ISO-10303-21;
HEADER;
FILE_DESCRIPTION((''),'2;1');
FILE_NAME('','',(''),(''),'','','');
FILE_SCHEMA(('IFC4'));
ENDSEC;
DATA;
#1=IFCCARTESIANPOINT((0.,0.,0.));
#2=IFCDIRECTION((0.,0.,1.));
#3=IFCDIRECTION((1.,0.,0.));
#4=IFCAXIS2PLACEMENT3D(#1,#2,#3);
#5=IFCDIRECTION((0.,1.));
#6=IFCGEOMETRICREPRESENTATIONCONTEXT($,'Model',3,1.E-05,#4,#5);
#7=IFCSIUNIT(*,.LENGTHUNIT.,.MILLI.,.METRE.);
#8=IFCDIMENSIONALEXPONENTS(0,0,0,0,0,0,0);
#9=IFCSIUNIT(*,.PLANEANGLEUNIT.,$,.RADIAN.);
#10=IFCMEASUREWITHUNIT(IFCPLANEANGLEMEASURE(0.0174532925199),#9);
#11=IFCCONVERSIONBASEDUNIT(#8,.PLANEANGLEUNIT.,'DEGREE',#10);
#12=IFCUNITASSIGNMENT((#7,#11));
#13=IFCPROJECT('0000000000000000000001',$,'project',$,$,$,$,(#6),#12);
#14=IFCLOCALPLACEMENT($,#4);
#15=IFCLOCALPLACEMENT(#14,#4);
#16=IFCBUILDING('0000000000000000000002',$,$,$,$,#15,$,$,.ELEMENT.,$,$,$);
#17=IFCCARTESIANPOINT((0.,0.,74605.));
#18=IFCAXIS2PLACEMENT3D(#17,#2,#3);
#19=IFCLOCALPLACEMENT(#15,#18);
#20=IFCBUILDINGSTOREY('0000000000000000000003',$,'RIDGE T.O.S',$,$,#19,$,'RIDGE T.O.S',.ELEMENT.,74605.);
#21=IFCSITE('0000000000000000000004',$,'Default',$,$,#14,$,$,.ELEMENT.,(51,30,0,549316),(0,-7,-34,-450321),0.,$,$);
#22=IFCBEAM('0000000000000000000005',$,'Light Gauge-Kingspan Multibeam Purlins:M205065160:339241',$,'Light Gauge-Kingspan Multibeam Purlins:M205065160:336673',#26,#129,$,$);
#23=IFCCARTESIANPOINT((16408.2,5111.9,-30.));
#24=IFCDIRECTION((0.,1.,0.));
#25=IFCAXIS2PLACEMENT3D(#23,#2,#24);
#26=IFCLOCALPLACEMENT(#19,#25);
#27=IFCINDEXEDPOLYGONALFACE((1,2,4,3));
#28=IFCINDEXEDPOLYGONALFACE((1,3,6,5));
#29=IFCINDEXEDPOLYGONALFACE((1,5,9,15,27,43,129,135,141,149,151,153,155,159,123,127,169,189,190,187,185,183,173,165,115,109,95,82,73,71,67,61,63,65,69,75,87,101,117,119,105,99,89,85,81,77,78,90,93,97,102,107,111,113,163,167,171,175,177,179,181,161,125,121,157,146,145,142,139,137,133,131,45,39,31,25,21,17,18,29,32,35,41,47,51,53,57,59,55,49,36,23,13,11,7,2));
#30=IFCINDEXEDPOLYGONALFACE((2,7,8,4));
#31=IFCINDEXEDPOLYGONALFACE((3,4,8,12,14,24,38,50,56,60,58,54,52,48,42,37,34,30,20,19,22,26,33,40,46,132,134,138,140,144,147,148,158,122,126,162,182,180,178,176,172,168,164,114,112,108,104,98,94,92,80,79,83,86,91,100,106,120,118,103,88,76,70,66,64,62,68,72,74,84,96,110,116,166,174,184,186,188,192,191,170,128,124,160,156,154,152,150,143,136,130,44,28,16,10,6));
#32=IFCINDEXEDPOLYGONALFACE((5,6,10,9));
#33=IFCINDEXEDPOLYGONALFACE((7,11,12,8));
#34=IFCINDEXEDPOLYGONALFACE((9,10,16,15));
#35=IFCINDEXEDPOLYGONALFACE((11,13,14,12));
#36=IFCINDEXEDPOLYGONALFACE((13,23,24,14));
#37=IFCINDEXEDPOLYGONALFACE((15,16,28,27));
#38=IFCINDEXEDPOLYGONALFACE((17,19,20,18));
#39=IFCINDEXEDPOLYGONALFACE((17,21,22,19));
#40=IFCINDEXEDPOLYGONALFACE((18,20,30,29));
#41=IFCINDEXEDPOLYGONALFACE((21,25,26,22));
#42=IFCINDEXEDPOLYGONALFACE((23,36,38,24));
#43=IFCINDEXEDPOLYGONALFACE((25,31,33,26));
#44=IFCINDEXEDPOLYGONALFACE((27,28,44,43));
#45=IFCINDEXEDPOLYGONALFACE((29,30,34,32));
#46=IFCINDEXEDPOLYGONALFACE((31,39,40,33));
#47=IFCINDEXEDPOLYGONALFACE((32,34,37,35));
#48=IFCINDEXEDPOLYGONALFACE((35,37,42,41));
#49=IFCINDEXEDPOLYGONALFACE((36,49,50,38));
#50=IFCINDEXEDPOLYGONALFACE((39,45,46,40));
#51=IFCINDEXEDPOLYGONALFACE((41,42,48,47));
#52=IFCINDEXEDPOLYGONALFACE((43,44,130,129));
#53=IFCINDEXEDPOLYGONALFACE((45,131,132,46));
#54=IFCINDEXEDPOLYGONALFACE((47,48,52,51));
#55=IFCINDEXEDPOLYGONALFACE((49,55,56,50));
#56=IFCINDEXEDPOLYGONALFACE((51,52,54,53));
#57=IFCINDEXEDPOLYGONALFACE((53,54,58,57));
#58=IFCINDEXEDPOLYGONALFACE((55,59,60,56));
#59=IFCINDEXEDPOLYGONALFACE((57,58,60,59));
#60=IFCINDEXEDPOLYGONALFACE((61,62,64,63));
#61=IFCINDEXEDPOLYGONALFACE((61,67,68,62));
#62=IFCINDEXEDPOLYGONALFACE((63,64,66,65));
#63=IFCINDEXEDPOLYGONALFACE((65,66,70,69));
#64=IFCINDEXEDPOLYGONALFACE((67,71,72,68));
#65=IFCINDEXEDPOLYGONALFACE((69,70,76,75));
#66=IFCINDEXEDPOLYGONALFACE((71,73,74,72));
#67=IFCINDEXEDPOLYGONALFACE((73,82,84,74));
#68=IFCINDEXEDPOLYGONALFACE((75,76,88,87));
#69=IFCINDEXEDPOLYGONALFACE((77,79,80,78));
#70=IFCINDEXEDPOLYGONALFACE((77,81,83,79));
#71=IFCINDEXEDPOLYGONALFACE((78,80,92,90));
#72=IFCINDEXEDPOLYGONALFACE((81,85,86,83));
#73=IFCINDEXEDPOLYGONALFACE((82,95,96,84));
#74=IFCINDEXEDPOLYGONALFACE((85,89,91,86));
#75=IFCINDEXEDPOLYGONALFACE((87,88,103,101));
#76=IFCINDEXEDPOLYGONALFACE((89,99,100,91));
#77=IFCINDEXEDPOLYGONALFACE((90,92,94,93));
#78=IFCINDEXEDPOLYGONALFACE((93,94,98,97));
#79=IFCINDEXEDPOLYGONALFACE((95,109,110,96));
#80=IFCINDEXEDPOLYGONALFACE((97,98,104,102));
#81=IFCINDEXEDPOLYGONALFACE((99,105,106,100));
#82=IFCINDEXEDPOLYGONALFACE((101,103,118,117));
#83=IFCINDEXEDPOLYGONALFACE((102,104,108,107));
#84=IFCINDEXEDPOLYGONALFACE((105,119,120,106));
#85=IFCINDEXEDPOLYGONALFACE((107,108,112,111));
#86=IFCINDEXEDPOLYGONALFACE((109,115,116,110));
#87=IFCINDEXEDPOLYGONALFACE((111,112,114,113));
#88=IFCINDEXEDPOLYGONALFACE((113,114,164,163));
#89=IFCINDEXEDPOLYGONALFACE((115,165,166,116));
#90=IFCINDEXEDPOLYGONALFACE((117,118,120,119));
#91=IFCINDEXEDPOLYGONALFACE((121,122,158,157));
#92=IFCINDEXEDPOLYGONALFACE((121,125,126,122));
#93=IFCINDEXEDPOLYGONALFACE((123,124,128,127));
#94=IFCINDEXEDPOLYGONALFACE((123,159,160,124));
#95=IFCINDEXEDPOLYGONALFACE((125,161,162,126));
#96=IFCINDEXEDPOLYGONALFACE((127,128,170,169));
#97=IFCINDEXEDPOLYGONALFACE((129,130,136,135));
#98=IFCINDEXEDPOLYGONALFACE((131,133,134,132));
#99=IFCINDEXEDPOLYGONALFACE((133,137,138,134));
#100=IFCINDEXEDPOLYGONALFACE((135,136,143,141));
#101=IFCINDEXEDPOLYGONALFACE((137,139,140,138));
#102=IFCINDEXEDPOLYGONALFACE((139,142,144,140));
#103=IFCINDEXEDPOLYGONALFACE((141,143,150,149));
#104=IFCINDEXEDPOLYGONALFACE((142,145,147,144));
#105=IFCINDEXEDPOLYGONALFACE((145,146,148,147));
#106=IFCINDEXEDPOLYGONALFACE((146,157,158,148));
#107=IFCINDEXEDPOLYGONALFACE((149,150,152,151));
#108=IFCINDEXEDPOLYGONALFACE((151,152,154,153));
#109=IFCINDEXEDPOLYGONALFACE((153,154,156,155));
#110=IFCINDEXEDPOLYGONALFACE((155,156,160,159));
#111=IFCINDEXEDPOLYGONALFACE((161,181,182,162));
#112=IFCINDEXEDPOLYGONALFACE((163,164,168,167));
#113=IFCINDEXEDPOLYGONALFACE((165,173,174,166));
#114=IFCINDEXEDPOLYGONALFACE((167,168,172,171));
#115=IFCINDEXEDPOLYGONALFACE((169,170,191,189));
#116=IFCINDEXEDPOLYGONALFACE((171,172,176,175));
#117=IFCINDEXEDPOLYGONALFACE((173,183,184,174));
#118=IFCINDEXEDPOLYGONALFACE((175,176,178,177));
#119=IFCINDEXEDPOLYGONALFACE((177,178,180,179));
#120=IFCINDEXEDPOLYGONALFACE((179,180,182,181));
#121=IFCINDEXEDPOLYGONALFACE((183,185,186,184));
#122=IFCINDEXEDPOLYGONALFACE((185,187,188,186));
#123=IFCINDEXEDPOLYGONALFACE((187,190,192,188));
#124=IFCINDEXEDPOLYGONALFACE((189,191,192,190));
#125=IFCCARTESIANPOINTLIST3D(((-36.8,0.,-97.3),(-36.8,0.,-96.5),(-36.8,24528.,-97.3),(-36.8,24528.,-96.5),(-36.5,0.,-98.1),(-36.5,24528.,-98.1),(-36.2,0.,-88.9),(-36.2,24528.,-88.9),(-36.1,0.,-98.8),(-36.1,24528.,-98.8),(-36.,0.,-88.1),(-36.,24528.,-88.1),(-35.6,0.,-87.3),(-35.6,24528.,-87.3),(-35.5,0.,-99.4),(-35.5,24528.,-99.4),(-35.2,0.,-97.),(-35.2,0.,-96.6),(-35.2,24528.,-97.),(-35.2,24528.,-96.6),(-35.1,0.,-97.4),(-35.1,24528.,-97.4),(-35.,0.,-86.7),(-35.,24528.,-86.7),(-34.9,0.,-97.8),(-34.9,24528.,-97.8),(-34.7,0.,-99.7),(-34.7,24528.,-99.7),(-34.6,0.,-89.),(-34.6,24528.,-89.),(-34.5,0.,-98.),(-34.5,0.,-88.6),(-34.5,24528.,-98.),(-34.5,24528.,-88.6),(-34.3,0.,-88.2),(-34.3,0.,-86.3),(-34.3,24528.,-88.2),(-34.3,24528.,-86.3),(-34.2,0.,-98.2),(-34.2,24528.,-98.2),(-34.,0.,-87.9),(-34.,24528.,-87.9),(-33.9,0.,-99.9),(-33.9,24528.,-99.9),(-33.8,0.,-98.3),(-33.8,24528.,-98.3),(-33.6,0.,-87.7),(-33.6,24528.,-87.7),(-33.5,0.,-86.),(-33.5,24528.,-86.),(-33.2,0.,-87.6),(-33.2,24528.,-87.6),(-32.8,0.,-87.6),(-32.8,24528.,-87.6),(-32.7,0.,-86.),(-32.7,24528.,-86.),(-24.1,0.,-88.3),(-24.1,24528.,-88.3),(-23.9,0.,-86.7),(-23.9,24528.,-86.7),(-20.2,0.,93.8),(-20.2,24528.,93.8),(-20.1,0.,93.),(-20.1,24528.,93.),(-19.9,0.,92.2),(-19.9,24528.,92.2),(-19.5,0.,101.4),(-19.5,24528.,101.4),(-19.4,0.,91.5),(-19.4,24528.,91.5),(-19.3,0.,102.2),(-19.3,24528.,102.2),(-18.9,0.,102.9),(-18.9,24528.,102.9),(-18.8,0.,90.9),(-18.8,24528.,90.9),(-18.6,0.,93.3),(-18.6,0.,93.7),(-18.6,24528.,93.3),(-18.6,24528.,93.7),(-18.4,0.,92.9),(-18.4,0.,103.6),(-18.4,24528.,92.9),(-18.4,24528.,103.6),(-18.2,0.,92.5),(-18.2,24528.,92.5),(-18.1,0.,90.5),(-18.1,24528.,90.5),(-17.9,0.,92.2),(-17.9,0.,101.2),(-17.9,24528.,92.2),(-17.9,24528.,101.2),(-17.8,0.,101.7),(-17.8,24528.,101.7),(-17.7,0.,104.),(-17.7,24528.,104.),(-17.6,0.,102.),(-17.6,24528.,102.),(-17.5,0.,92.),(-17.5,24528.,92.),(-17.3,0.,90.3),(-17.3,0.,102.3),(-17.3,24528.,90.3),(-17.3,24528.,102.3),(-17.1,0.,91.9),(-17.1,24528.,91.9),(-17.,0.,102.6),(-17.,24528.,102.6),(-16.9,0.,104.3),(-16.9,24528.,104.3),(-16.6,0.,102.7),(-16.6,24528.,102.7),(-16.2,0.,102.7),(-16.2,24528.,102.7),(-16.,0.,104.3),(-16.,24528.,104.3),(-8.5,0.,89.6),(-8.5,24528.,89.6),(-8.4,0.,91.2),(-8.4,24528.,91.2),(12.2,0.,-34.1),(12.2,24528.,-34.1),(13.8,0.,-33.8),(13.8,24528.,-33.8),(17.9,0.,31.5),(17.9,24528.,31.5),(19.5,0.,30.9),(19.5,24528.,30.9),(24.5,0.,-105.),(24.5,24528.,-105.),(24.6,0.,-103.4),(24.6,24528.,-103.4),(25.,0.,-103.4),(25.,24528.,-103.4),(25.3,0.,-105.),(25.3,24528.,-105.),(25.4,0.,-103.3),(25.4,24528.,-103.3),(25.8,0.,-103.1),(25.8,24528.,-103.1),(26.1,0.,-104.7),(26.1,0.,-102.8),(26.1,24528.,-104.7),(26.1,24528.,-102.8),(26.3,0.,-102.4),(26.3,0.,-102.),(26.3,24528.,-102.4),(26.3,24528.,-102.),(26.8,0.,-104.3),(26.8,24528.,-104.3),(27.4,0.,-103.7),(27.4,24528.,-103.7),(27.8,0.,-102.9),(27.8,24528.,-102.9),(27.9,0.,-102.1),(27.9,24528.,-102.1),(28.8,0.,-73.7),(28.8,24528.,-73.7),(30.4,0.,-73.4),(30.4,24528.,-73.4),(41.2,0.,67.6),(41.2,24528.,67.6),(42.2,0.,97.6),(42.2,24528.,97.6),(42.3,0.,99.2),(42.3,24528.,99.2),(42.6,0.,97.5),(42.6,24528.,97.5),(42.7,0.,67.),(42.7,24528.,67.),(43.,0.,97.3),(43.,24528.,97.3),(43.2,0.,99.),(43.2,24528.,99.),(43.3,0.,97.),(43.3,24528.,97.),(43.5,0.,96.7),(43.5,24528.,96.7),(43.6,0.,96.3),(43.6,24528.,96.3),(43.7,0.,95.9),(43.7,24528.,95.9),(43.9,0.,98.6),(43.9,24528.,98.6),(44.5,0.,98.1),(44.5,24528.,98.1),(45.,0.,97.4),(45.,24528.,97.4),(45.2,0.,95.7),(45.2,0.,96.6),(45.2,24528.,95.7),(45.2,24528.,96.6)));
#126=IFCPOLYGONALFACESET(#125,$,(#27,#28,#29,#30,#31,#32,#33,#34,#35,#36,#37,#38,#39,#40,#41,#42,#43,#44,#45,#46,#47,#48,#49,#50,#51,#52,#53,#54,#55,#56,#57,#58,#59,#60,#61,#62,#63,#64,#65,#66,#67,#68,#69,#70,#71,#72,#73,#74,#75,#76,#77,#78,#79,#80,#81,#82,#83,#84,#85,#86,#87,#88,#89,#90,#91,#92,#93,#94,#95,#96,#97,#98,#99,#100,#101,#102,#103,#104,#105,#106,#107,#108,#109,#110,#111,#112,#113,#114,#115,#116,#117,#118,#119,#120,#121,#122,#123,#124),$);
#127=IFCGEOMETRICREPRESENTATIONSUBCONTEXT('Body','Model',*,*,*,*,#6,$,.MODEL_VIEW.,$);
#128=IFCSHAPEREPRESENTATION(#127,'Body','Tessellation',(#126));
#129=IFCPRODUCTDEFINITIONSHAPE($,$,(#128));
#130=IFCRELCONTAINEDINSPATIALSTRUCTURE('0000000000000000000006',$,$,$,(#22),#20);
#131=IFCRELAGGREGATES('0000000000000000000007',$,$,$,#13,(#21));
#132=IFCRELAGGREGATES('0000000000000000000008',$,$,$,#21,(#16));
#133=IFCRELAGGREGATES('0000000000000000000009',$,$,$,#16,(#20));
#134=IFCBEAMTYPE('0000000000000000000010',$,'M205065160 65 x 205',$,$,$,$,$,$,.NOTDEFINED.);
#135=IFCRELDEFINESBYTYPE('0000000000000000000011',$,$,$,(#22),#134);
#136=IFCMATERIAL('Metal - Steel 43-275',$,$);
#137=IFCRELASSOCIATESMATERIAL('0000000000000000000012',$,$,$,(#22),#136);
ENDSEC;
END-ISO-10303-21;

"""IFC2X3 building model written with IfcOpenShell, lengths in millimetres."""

from ifc_helpers import new_model, entity, si_unit, converted_unit, point, direction, frame, frame_2d, origin_with_axes, place, context, subcontext, project, spatial, polyline, circle_curve, parameter, trimmed, segment, composite_curve, outline, extrude, material, type_object, element, save


model = new_model("IFC2X3")

# Units and contexts
model_context = context("Model", 3, precision=1e-05, world=origin_with_axes(), true_north=direction((0.0, 1.0)))
body_context = subcontext(model_context, "Body", "Model", "MODEL_VIEW")
ifc_project = project(units=[si_unit("LENGTHUNIT", "METRE", prefix="MILLI"), converted_unit("PLANEANGLEUNIT", "DEGREE", entity("IfcPlaneAngleMeasure", 0.0174532925199), si_unit("PLANEANGLEUNIT", "RADIAN"), dimensions=[0, 0, 0, 0, 0, 0, 0])], contexts=[model_context])

# Site, building, storey
site_placement = place(None, origin_with_axes())
site = spatial("IfcSite", under=ifc_project, at=site_placement, Name="Default", CompositionType="ELEMENT", RefLatitude=(51, 30, 0, 549316), RefLongitude=(0, -7, -34, -450321), RefElevation=0.0)
building_placement = place(site_placement, origin_with_axes())
building = spatial("IfcBuilding", under=site, at=building_placement, CompositionType="ELEMENT")
storey_placement = place(building_placement, frame((0.0, 0.0, 74605.0), z_axis=(0.0, 0.0, 1.0), x_axis=(1.0, 0.0, 0.0)))
storey = spatial("IfcBuildingStorey", under=building, at=storey_placement, Name="RIDGE T.O.S", LongName="RIDGE T.O.S", CompositionType="ELEMENT", Elevation=74605.0)

# Beam
ifc_material = material(Name="Metal - Steel 43-275")
beam_type_1 = type_object("IfcBeamType", Name="M205065160 65 x 205", PredefinedType="NOTDEFINED")
beam_1_placement = place(storey_placement, frame((16408.2, 5111.9, -30.0), z_axis=(0.0, 0.0, 1.0), x_axis=(0.0, 1.0, 0.0)))
element("IfcBeam", 1, at=beam_1_placement, inside=storey, type_object=beam_type_1, material=ifc_material, Name="Light Gauge-Kingspan Multibeam Purlins:M205065160:339241", ObjectType="Light Gauge-Kingspan Multibeam Purlins:M205065160:336673", context=body_context, shape_type="SweptSolid", body=[
    extrude(outline(composite_curve([segment(polyline([(-33.5, -102.5), (25.1, -102.5)]), True, "CONTINUOUS"), segment(trimmed(circle_curve(frame_2d((25.1, -99.3), x_axis=(0.0, -1.0)), 3.2), [point((25.1, -102.5)), parameter(0.0)], [point((28.3, -99.3)), parameter(90.0)], True, "CARTESIAN"), True, "CONTINUOUS"), segment(polyline([(28.3, -99.3), (28.3, -91.7)]), True, "CONTINUOUS"), segment(trimmed(circle_curve(frame_2d((25.1, -91.7), x_axis=(1.0, 0.0)), 3.2), [point((28.3, -91.7)), parameter(0.0)], [point((25.1, -88.5)), parameter(90.0)], True, "CARTESIAN"), True, "CONTINUOUS"), segment(polyline([(25.1, -88.5), (16.3, -88.5), (16.3, -90.1), (25.1, -90.1)]), True, "CONTINUOUS"), segment(trimmed(circle_curve(frame_2d((25.1, -91.7), x_axis=(1.0, 0.0)), 1.6), [point((25.1, -90.1)), parameter(90.0)], [point((26.7, -91.7)), parameter(0.0)], False, "CARTESIAN"), True, "CONTINUOUS"), segment(polyline([(26.7, -91.7), (26.7, -99.3)]), True, "CONTINUOUS"), segment(trimmed(circle_curve(frame_2d((25.1, -99.3), x_axis=(0.0, -1.0)), 1.6), [point((26.7, -99.3)), parameter(90.0)], [point((25.1, -100.9)), parameter(0.0)], False, "CARTESIAN"), True, "CONTINUOUS"), segment(polyline([(25.1, -100.9), (-33.5, -100.9)]), True, "CONTINUOUS"), segment(trimmed(circle_curve(frame_2d((-33.5, -99.3), x_axis=(-1.0, 0.0)), 1.6), [point((-33.5, -100.9)), parameter(90.0)], [point((-35.1, -99.3)), parameter(0.0)], False, "CARTESIAN"), True, "CONTINUOUS"), segment(polyline([(-35.1, -99.3), (-35.1, -70.9), (-15.1, -32.9), (-15.1, 32.9), (-35.1, 70.9), (-35.1, 99.3)]), True, "CONTINUOUS"), segment(trimmed(circle_curve(frame_2d((-33.5, 99.3), x_axis=(0.0, 1.0)), 1.6), [point((-35.1, 99.3)), parameter(90.0)], [point((-33.5, 100.9)), parameter(0.0)], False, "CARTESIAN"), True, "CONTINUOUS"), segment(polyline([(-33.5, 100.9), (25.1, 100.9)]), True, "CONTINUOUS"), segment(trimmed(circle_curve(frame_2d((25.1, 99.3), x_axis=(1.0, 0.0)), 1.6), [point((25.1, 100.9)), parameter(90.0)], [point((26.7, 99.3)), parameter(0.0)], False, "CARTESIAN"), True, "CONTINUOUS"), segment(polyline([(26.7, 99.3), (26.7, 91.7)]), True, "CONTINUOUS"), segment(trimmed(circle_curve(frame_2d((25.1, 91.7), x_axis=(0.0, -1.0)), 1.6), [point((26.7, 91.7)), parameter(90.0)], [point((25.1, 90.1)), parameter(0.0)], False, "CARTESIAN"), True, "CONTINUOUS"), segment(polyline([(25.1, 90.1), (16.3, 90.1), (16.3, 88.5), (25.1, 88.5)]), True, "CONTINUOUS"), segment(trimmed(circle_curve(frame_2d((25.1, 91.7), x_axis=(0.0, -1.0)), 3.2), [point((25.1, 88.5)), parameter(0.0)], [point((28.3, 91.7)), parameter(90.0)], True, "CARTESIAN"), True, "CONTINUOUS"), segment(polyline([(28.3, 91.7), (28.3, 99.3)]), True, "CONTINUOUS"), segment(trimmed(circle_curve(frame_2d((25.1, 99.3), x_axis=(1.0, 0.0)), 3.2), [point((28.3, 99.3)), parameter(0.0)], [point((25.1, 102.5)), parameter(90.0)], True, "CARTESIAN"), True, "CONTINUOUS"), segment(polyline([(25.1, 102.5), (-33.5, 102.5)]), True, "CONTINUOUS"), segment(trimmed(circle_curve(frame_2d((-33.5, 99.3), x_axis=(0.0, 1.0)), 3.2), [point((-33.5, 102.5)), parameter(0.0)], [point((-36.7, 99.3)), parameter(90.0)], True, "CARTESIAN"), True, "CONTINUOUS"), segment(polyline([(-36.7, 99.3), (-36.7, 70.5), (-16.7, 32.5), (-16.7, -32.5), (-36.7, -70.5), (-36.7, -99.3)]), True, "CONTINUOUS"), segment(trimmed(circle_curve(frame_2d((-33.5, -99.3), x_axis=(-1.0, 0.0)), 3.2), [point((-36.7, -99.3)), parameter(0.0)], [point((-33.5, -102.5)), parameter(90.0)], True, "CARTESIAN"), True, "CONTINUOUS")], self_intersect=False)), frame((0.0, 24528.0, 0.0), z_axis=(0.0, -1.0, 0.0), x_axis=(-0.996195, 0.0, 0.087156)), (0.0, 0.0, 1.0), 24528.0),
])

save(model, "model.ifc")
